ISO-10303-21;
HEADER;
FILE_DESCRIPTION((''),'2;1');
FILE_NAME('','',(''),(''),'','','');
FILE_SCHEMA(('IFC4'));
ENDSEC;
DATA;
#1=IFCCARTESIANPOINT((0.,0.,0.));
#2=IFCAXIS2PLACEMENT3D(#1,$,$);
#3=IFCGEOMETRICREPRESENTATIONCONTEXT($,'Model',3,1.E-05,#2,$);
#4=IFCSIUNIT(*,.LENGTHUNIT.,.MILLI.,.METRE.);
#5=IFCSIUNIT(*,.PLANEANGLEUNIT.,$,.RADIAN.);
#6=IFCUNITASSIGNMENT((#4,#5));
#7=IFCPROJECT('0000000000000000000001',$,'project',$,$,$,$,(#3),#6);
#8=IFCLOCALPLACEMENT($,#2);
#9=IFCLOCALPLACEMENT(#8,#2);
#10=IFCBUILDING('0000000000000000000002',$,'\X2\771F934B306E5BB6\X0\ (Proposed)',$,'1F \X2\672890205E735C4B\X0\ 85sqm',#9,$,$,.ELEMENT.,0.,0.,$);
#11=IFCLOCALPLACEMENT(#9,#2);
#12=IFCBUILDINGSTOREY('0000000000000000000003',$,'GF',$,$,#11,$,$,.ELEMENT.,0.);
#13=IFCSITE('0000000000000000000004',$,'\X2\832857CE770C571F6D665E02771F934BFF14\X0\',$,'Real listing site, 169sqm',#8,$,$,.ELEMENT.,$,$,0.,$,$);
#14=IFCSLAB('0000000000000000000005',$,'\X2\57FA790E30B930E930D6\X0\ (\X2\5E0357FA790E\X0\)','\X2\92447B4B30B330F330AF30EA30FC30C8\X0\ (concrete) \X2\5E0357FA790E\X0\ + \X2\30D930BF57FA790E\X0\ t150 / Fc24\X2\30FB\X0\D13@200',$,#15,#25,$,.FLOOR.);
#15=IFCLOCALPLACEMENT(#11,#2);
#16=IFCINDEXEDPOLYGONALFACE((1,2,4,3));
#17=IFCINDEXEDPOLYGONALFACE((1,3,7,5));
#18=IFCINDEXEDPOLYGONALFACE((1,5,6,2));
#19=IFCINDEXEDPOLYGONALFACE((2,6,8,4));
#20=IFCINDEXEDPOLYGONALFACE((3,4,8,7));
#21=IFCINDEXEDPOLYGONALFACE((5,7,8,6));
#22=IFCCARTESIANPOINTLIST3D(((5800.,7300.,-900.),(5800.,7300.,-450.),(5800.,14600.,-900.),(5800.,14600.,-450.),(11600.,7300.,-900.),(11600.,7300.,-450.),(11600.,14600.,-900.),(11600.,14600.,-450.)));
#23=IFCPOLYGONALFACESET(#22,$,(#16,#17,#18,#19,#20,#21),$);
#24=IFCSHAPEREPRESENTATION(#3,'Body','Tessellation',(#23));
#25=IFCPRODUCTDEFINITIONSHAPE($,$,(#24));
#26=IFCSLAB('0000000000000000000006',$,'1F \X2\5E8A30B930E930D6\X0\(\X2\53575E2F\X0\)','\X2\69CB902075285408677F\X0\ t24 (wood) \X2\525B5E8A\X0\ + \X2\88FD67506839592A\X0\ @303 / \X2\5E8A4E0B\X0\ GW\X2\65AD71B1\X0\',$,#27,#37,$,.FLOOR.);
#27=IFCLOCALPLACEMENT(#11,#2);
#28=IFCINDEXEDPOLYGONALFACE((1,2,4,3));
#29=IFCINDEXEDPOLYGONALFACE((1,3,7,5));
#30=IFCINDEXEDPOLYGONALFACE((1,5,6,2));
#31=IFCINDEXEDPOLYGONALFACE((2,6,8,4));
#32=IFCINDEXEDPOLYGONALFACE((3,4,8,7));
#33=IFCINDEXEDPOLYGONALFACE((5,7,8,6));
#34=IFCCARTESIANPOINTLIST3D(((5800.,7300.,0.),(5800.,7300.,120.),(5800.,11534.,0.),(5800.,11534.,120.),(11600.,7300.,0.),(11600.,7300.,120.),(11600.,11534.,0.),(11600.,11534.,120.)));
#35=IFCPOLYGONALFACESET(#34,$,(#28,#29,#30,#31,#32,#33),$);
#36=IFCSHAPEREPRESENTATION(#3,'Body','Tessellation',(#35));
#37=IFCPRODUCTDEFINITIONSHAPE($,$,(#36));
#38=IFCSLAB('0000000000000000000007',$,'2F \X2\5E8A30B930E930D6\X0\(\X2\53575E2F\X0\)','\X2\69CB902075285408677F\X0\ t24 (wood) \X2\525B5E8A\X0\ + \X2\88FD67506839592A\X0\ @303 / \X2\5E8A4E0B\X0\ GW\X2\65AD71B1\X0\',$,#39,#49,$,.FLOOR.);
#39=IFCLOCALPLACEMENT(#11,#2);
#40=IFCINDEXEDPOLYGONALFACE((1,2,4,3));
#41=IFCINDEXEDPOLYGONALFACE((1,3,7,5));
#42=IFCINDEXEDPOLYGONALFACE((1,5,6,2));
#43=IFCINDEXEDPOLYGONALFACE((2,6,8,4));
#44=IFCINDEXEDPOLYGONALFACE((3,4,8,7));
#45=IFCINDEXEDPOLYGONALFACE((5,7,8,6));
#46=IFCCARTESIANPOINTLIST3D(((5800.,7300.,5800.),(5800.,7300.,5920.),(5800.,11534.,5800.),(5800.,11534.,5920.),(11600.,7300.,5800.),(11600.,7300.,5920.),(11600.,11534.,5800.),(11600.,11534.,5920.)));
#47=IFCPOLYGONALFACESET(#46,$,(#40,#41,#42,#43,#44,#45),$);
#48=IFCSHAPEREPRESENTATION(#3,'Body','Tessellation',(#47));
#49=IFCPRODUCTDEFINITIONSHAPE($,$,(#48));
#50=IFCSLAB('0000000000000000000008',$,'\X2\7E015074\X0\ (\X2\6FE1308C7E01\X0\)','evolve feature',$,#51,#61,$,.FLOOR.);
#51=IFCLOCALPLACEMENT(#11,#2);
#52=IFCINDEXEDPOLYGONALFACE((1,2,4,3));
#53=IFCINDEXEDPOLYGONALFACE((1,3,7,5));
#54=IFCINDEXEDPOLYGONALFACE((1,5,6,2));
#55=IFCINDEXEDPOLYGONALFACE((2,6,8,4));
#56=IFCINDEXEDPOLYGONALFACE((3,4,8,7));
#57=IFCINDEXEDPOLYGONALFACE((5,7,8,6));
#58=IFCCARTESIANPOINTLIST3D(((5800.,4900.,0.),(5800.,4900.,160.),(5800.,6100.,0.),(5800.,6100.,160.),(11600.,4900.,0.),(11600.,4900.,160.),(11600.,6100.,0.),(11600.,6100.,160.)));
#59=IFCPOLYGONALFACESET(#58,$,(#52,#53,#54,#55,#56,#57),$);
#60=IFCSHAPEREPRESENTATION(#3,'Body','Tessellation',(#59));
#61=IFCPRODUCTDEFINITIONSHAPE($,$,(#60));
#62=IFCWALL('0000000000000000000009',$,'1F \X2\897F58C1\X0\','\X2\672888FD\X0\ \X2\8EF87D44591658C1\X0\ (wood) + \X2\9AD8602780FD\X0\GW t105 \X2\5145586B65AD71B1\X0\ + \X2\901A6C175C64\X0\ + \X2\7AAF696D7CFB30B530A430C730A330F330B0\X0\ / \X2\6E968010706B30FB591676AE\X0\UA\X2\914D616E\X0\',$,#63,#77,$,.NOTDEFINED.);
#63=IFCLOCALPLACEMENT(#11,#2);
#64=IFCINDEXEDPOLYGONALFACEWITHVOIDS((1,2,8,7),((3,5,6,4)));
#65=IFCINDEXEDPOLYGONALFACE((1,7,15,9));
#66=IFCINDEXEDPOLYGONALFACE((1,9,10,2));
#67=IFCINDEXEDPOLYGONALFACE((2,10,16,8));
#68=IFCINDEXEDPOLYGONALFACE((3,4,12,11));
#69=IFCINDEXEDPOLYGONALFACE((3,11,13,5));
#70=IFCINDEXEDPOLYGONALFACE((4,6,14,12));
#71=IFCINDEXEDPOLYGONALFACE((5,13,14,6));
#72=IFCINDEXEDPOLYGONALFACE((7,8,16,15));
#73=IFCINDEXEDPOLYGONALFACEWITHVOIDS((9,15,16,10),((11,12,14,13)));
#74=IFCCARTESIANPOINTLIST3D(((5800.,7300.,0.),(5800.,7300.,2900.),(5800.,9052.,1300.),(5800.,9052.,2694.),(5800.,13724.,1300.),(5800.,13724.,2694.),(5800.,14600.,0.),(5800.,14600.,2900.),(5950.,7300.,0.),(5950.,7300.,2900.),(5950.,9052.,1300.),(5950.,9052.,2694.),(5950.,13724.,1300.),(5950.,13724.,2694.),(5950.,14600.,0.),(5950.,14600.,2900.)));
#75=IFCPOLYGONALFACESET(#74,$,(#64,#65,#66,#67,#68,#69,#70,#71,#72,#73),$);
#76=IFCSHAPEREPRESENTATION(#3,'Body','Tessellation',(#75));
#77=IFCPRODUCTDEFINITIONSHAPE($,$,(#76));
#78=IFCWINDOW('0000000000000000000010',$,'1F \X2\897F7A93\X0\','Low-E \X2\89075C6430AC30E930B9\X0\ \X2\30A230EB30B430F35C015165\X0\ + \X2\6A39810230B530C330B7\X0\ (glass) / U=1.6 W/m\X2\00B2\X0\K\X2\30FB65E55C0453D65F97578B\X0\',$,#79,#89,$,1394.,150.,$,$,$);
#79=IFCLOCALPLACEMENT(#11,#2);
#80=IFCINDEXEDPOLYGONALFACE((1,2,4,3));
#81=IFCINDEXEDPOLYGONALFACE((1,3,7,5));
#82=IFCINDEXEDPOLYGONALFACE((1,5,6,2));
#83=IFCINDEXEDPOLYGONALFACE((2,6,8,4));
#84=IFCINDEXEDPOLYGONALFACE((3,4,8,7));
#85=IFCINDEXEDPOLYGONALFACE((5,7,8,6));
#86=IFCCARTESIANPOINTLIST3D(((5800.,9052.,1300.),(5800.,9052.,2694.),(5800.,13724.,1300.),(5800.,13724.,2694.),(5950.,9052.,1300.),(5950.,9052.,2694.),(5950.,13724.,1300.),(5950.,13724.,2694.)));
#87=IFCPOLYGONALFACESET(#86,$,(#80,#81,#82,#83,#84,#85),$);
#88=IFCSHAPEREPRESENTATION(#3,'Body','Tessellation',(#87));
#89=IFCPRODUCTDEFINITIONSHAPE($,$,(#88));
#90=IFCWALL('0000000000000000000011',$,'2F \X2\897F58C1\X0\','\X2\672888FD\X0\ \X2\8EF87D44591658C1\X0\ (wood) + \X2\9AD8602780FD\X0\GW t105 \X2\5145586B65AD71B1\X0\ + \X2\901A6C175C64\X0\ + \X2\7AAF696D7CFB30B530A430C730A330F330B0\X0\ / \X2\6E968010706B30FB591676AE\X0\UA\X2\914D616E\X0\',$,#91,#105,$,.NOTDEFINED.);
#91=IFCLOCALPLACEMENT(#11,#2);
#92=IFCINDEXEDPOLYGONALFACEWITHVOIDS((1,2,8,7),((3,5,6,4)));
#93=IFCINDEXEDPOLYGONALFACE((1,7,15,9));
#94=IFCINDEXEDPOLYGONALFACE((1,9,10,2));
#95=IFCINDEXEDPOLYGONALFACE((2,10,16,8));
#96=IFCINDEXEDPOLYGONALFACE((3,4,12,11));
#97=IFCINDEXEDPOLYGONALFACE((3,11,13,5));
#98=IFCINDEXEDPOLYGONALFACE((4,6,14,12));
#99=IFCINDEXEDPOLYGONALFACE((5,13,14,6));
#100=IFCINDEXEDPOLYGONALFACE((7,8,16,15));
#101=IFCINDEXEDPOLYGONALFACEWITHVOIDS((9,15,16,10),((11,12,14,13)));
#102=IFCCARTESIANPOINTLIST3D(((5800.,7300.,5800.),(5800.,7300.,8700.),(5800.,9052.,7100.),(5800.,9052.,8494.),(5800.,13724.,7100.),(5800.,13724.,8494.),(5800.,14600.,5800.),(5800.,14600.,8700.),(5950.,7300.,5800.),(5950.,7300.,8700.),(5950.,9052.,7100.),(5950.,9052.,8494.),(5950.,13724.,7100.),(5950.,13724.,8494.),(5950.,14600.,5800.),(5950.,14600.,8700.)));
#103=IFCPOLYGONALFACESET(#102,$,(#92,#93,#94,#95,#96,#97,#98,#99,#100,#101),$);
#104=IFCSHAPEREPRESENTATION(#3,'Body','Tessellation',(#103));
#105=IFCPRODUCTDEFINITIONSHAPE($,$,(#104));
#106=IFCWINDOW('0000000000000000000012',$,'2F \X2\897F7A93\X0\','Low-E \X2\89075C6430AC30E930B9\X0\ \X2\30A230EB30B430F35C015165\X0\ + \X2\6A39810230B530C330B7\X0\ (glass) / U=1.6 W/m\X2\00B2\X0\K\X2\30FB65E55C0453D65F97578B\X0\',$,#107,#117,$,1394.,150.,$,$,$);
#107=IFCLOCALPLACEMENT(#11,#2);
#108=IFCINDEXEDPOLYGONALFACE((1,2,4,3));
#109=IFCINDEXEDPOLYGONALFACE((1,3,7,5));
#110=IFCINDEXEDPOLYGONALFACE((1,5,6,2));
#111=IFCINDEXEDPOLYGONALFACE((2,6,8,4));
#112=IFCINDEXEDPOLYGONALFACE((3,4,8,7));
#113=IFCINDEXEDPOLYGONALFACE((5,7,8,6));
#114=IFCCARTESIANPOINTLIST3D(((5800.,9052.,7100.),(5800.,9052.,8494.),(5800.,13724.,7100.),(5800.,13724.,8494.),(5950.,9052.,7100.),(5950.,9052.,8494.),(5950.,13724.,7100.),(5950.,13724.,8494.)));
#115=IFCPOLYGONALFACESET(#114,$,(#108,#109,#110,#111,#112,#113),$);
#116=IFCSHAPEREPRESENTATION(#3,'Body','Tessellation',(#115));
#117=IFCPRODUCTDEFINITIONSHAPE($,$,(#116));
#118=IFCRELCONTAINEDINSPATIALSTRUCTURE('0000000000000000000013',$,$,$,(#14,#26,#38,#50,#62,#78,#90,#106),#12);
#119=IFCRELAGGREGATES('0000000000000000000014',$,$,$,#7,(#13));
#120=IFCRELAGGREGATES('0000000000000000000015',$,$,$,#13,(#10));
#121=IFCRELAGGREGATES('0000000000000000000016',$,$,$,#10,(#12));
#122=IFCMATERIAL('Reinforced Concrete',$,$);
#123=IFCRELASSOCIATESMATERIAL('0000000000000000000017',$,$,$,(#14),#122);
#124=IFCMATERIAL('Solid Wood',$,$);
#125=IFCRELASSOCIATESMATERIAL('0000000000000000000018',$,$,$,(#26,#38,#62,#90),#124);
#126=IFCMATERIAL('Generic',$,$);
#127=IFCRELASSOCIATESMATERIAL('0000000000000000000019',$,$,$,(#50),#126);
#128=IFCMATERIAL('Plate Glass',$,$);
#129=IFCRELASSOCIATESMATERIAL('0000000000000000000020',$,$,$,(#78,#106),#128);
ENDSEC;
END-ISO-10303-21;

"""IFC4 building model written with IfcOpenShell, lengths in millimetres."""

from ifc_helpers import new_model, si_unit, frame, frame_2d, origin, place, context, project, spatial, rectangle, extrude, material, element, fill, save


model = new_model("IFC4")

# Units and contexts
model_context = context("Model", 3, precision=1e-05, world=origin())
ifc_project = project(units=[si_unit("LENGTHUNIT", "METRE", prefix="MILLI"), si_unit("PLANEANGLEUNIT", "RADIAN")], contexts=[model_context])

# Site, building, storey
site_placement = place(None, origin())
site = spatial("IfcSite", under=ifc_project, at=site_placement, Name="茨城県土浦市真鍋４", ObjectType="Real listing site, 169sqm", CompositionType="ELEMENT", RefElevation=0.0)
building_placement = place(site_placement, origin())
building = spatial("IfcBuilding", under=site, at=building_placement, Name="真鍋の家 (Proposed)", ObjectType="1F 木造平屋 85sqm", CompositionType="ELEMENT", ElevationOfRefHeight=0.0, ElevationOfTerrain=0.0)
storey_placement = place(building_placement, origin())
storey = spatial("IfcBuildingStorey", under=building, at=storey_placement, Name="GF", CompositionType="ELEMENT", Elevation=0.0)

# Slabs
ifc_material_1 = material(Name="Reinforced Concrete")
slab_1_placement = place(storey_placement, frame((2900.0, 3650.0, -450.0)))
element("IfcSlab", 1, at=slab_1_placement, inside=storey, material=ifc_material_1, Name="基礎スラブ (布基礎)", Description="鉄筋コンクリート (concrete) 布基礎 + ベタ基礎 t150 / Fc24・D13@200", PredefinedType="FLOOR", context=model_context, shape_type="SweptSolid", body=[
    extrude(rectangle(XDim=5800.0, YDim=7300.0, at=frame_2d((2900.0, 3650.0))), frame((2900.0, 3650.0, -450.0)), (0.0, 0.0, 1.0), 450.0),
])
ifc_material_2 = material(Name="Solid Wood")
slab_2_placement = place(storey_placement, frame((2900.0, 3650.0, 0.0)))
element("IfcSlab", 2, at=slab_2_placement, inside=storey, material=ifc_material_2, Name="1F 床スラブ(南帯)", Description="構造用合板 t24 (wood) 剛床 + 製材根太 @303 / 床下 GW断熱", PredefinedType="FLOOR", context=model_context, shape_type="SweptSolid", body=[
    extrude(rectangle(XDim=5800.0, YDim=4234.0, at=frame_2d((2900.0, 2117.0))), frame((2900.0, 3650.0, 0.0)), (0.0, 0.0, 1.0), 120.0),
])
slab_3_placement = place(storey_placement, frame((2900.0, 3650.0, 2900.0)))
element("IfcSlab", 3, at=slab_3_placement, inside=storey, material=ifc_material_2, Name="2F 床スラブ(南帯)", Description="構造用合板 t24 (wood) 剛床 + 製材根太 @303 / 床下 GW断熱", PredefinedType="FLOOR", context=model_context, shape_type="SweptSolid", body=[
    extrude(rectangle(XDim=5800.0, YDim=4234.0, at=frame_2d((2900.0, 2117.0))), frame((2900.0, 3650.0, 2900.0)), (0.0, 0.0, 1.0), 120.0),
])
ifc_material_3 = material(Name="Generic")
slab_4_placement = place(storey_placement, frame((2900.0, 2450.0, 0.0)))
element("IfcSlab", 4, at=slab_4_placement, inside=storey, material=ifc_material_3, Name="縁側 (濡れ縁)", Description="evolve feature", PredefinedType="FLOOR", context=model_context, shape_type="SweptSolid", body=[
    extrude(rectangle(XDim=5800.0, YDim=1200.0, at=frame_2d((2900.0, 600.0))), frame((2900.0, 2450.0, 0.0)), (0.0, 0.0, 1.0), 160.0),
])

# Shared definitions
ifc_material_4 = material(Name="Plate Glass")

# Wall, opening, window
wall_1_placement = place(storey_placement, frame((2900.0, 3650.0, 0.0)))
wall_1 = element("IfcWall", 5, at=wall_1_placement, inside=storey, material=ifc_material_2, Name="1F 西壁", Description="木製 軸組外壁 (wood) + 高性能GW t105 充填断熱 + 通気層 + 窯業系サイディング / 準耐火・外皮UA配慮", PredefinedType="NOTDEFINED", context=model_context, shape_type="SweptSolid", body=[
    extrude(rectangle(XDim=150.0, YDim=7300.0, at=frame_2d((75.0, 3650.0))), frame((2900.0, 3650.0, 0.0)), (0.0, 0.0, 1.0), 2900.0),
])
opening_1_placement = place(storey_placement, frame((2900.0, 4526.0, 650.0)))
opening_1 = element("IfcOpeningElement", 6, at=opening_1_placement, cuts=wall_1, PredefinedType="NOTDEFINED", context=model_context, shape_type="SweptSolid", body=[
    extrude(rectangle(XDim=150.0, YDim=4672.0, at=frame_2d((75.0, 2336.0))), frame((2900.0, 4526.0, 650.0)), (0.0, 0.0, 1.0), 1394.0),
])
window_1_placement = place(storey_placement, frame((2900.0, 4526.0, 650.0)))
window_1 = element("IfcWindow", 7, at=window_1_placement, inside=storey, material=ifc_material_4, Name="1F 西窓", Description="Low-E 複層ガラス アルゴン封入 + 樹脂サッシ (glass) / U=1.6 W/m²K・日射取得型", OverallHeight=1394.0, OverallWidth=150.0, context=model_context, shape_type="SweptSolid", body=[
    extrude(rectangle(XDim=150.0, YDim=4672.0, at=frame_2d((75.0, 2336.0))), frame((2900.0, 4526.0, 650.0)), (0.0, 0.0, 1.0), 1394.0),
])
fill(opening_1, window_1)

# Wall, opening, window
wall_2_placement = place(storey_placement, frame((2900.0, 3650.0, 2900.0)))
wall_2 = element("IfcWall", 8, at=wall_2_placement, inside=storey, material=ifc_material_2, Name="2F 西壁", Description="木製 軸組外壁 (wood) + 高性能GW t105 充填断熱 + 通気層 + 窯業系サイディング / 準耐火・外皮UA配慮", PredefinedType="NOTDEFINED", context=model_context, shape_type="SweptSolid", body=[
    extrude(rectangle(XDim=150.0, YDim=7300.0, at=frame_2d((75.0, 3650.0))), frame((2900.0, 3650.0, 2900.0)), (0.0, 0.0, 1.0), 2900.0),
])
opening_2_placement = place(storey_placement, frame((2900.0, 4526.0, 3550.0)))
opening_2 = element("IfcOpeningElement", 9, at=opening_2_placement, cuts=wall_2, PredefinedType="NOTDEFINED", context=model_context, shape_type="SweptSolid", body=[
    extrude(rectangle(XDim=150.0, YDim=4672.0, at=frame_2d((75.0, 2336.0))), frame((2900.0, 4526.0, 3550.0)), (0.0, 0.0, 1.0), 1394.0),
])
window_2_placement = place(storey_placement, frame((2900.0, 4526.0, 3550.0)))
window_2 = element("IfcWindow", 10, at=window_2_placement, inside=storey, material=ifc_material_4, Name="2F 西窓", Description="Low-E 複層ガラス アルゴン封入 + 樹脂サッシ (glass) / U=1.6 W/m²K・日射取得型", OverallHeight=1394.0, OverallWidth=150.0, context=model_context, shape_type="SweptSolid", body=[
    extrude(rectangle(XDim=150.0, YDim=4672.0, at=frame_2d((75.0, 2336.0))), frame((2900.0, 4526.0, 3550.0)), (0.0, 0.0, 1.0), 1394.0),
])
fill(opening_2, window_2)

save(model, "model.ifc")
